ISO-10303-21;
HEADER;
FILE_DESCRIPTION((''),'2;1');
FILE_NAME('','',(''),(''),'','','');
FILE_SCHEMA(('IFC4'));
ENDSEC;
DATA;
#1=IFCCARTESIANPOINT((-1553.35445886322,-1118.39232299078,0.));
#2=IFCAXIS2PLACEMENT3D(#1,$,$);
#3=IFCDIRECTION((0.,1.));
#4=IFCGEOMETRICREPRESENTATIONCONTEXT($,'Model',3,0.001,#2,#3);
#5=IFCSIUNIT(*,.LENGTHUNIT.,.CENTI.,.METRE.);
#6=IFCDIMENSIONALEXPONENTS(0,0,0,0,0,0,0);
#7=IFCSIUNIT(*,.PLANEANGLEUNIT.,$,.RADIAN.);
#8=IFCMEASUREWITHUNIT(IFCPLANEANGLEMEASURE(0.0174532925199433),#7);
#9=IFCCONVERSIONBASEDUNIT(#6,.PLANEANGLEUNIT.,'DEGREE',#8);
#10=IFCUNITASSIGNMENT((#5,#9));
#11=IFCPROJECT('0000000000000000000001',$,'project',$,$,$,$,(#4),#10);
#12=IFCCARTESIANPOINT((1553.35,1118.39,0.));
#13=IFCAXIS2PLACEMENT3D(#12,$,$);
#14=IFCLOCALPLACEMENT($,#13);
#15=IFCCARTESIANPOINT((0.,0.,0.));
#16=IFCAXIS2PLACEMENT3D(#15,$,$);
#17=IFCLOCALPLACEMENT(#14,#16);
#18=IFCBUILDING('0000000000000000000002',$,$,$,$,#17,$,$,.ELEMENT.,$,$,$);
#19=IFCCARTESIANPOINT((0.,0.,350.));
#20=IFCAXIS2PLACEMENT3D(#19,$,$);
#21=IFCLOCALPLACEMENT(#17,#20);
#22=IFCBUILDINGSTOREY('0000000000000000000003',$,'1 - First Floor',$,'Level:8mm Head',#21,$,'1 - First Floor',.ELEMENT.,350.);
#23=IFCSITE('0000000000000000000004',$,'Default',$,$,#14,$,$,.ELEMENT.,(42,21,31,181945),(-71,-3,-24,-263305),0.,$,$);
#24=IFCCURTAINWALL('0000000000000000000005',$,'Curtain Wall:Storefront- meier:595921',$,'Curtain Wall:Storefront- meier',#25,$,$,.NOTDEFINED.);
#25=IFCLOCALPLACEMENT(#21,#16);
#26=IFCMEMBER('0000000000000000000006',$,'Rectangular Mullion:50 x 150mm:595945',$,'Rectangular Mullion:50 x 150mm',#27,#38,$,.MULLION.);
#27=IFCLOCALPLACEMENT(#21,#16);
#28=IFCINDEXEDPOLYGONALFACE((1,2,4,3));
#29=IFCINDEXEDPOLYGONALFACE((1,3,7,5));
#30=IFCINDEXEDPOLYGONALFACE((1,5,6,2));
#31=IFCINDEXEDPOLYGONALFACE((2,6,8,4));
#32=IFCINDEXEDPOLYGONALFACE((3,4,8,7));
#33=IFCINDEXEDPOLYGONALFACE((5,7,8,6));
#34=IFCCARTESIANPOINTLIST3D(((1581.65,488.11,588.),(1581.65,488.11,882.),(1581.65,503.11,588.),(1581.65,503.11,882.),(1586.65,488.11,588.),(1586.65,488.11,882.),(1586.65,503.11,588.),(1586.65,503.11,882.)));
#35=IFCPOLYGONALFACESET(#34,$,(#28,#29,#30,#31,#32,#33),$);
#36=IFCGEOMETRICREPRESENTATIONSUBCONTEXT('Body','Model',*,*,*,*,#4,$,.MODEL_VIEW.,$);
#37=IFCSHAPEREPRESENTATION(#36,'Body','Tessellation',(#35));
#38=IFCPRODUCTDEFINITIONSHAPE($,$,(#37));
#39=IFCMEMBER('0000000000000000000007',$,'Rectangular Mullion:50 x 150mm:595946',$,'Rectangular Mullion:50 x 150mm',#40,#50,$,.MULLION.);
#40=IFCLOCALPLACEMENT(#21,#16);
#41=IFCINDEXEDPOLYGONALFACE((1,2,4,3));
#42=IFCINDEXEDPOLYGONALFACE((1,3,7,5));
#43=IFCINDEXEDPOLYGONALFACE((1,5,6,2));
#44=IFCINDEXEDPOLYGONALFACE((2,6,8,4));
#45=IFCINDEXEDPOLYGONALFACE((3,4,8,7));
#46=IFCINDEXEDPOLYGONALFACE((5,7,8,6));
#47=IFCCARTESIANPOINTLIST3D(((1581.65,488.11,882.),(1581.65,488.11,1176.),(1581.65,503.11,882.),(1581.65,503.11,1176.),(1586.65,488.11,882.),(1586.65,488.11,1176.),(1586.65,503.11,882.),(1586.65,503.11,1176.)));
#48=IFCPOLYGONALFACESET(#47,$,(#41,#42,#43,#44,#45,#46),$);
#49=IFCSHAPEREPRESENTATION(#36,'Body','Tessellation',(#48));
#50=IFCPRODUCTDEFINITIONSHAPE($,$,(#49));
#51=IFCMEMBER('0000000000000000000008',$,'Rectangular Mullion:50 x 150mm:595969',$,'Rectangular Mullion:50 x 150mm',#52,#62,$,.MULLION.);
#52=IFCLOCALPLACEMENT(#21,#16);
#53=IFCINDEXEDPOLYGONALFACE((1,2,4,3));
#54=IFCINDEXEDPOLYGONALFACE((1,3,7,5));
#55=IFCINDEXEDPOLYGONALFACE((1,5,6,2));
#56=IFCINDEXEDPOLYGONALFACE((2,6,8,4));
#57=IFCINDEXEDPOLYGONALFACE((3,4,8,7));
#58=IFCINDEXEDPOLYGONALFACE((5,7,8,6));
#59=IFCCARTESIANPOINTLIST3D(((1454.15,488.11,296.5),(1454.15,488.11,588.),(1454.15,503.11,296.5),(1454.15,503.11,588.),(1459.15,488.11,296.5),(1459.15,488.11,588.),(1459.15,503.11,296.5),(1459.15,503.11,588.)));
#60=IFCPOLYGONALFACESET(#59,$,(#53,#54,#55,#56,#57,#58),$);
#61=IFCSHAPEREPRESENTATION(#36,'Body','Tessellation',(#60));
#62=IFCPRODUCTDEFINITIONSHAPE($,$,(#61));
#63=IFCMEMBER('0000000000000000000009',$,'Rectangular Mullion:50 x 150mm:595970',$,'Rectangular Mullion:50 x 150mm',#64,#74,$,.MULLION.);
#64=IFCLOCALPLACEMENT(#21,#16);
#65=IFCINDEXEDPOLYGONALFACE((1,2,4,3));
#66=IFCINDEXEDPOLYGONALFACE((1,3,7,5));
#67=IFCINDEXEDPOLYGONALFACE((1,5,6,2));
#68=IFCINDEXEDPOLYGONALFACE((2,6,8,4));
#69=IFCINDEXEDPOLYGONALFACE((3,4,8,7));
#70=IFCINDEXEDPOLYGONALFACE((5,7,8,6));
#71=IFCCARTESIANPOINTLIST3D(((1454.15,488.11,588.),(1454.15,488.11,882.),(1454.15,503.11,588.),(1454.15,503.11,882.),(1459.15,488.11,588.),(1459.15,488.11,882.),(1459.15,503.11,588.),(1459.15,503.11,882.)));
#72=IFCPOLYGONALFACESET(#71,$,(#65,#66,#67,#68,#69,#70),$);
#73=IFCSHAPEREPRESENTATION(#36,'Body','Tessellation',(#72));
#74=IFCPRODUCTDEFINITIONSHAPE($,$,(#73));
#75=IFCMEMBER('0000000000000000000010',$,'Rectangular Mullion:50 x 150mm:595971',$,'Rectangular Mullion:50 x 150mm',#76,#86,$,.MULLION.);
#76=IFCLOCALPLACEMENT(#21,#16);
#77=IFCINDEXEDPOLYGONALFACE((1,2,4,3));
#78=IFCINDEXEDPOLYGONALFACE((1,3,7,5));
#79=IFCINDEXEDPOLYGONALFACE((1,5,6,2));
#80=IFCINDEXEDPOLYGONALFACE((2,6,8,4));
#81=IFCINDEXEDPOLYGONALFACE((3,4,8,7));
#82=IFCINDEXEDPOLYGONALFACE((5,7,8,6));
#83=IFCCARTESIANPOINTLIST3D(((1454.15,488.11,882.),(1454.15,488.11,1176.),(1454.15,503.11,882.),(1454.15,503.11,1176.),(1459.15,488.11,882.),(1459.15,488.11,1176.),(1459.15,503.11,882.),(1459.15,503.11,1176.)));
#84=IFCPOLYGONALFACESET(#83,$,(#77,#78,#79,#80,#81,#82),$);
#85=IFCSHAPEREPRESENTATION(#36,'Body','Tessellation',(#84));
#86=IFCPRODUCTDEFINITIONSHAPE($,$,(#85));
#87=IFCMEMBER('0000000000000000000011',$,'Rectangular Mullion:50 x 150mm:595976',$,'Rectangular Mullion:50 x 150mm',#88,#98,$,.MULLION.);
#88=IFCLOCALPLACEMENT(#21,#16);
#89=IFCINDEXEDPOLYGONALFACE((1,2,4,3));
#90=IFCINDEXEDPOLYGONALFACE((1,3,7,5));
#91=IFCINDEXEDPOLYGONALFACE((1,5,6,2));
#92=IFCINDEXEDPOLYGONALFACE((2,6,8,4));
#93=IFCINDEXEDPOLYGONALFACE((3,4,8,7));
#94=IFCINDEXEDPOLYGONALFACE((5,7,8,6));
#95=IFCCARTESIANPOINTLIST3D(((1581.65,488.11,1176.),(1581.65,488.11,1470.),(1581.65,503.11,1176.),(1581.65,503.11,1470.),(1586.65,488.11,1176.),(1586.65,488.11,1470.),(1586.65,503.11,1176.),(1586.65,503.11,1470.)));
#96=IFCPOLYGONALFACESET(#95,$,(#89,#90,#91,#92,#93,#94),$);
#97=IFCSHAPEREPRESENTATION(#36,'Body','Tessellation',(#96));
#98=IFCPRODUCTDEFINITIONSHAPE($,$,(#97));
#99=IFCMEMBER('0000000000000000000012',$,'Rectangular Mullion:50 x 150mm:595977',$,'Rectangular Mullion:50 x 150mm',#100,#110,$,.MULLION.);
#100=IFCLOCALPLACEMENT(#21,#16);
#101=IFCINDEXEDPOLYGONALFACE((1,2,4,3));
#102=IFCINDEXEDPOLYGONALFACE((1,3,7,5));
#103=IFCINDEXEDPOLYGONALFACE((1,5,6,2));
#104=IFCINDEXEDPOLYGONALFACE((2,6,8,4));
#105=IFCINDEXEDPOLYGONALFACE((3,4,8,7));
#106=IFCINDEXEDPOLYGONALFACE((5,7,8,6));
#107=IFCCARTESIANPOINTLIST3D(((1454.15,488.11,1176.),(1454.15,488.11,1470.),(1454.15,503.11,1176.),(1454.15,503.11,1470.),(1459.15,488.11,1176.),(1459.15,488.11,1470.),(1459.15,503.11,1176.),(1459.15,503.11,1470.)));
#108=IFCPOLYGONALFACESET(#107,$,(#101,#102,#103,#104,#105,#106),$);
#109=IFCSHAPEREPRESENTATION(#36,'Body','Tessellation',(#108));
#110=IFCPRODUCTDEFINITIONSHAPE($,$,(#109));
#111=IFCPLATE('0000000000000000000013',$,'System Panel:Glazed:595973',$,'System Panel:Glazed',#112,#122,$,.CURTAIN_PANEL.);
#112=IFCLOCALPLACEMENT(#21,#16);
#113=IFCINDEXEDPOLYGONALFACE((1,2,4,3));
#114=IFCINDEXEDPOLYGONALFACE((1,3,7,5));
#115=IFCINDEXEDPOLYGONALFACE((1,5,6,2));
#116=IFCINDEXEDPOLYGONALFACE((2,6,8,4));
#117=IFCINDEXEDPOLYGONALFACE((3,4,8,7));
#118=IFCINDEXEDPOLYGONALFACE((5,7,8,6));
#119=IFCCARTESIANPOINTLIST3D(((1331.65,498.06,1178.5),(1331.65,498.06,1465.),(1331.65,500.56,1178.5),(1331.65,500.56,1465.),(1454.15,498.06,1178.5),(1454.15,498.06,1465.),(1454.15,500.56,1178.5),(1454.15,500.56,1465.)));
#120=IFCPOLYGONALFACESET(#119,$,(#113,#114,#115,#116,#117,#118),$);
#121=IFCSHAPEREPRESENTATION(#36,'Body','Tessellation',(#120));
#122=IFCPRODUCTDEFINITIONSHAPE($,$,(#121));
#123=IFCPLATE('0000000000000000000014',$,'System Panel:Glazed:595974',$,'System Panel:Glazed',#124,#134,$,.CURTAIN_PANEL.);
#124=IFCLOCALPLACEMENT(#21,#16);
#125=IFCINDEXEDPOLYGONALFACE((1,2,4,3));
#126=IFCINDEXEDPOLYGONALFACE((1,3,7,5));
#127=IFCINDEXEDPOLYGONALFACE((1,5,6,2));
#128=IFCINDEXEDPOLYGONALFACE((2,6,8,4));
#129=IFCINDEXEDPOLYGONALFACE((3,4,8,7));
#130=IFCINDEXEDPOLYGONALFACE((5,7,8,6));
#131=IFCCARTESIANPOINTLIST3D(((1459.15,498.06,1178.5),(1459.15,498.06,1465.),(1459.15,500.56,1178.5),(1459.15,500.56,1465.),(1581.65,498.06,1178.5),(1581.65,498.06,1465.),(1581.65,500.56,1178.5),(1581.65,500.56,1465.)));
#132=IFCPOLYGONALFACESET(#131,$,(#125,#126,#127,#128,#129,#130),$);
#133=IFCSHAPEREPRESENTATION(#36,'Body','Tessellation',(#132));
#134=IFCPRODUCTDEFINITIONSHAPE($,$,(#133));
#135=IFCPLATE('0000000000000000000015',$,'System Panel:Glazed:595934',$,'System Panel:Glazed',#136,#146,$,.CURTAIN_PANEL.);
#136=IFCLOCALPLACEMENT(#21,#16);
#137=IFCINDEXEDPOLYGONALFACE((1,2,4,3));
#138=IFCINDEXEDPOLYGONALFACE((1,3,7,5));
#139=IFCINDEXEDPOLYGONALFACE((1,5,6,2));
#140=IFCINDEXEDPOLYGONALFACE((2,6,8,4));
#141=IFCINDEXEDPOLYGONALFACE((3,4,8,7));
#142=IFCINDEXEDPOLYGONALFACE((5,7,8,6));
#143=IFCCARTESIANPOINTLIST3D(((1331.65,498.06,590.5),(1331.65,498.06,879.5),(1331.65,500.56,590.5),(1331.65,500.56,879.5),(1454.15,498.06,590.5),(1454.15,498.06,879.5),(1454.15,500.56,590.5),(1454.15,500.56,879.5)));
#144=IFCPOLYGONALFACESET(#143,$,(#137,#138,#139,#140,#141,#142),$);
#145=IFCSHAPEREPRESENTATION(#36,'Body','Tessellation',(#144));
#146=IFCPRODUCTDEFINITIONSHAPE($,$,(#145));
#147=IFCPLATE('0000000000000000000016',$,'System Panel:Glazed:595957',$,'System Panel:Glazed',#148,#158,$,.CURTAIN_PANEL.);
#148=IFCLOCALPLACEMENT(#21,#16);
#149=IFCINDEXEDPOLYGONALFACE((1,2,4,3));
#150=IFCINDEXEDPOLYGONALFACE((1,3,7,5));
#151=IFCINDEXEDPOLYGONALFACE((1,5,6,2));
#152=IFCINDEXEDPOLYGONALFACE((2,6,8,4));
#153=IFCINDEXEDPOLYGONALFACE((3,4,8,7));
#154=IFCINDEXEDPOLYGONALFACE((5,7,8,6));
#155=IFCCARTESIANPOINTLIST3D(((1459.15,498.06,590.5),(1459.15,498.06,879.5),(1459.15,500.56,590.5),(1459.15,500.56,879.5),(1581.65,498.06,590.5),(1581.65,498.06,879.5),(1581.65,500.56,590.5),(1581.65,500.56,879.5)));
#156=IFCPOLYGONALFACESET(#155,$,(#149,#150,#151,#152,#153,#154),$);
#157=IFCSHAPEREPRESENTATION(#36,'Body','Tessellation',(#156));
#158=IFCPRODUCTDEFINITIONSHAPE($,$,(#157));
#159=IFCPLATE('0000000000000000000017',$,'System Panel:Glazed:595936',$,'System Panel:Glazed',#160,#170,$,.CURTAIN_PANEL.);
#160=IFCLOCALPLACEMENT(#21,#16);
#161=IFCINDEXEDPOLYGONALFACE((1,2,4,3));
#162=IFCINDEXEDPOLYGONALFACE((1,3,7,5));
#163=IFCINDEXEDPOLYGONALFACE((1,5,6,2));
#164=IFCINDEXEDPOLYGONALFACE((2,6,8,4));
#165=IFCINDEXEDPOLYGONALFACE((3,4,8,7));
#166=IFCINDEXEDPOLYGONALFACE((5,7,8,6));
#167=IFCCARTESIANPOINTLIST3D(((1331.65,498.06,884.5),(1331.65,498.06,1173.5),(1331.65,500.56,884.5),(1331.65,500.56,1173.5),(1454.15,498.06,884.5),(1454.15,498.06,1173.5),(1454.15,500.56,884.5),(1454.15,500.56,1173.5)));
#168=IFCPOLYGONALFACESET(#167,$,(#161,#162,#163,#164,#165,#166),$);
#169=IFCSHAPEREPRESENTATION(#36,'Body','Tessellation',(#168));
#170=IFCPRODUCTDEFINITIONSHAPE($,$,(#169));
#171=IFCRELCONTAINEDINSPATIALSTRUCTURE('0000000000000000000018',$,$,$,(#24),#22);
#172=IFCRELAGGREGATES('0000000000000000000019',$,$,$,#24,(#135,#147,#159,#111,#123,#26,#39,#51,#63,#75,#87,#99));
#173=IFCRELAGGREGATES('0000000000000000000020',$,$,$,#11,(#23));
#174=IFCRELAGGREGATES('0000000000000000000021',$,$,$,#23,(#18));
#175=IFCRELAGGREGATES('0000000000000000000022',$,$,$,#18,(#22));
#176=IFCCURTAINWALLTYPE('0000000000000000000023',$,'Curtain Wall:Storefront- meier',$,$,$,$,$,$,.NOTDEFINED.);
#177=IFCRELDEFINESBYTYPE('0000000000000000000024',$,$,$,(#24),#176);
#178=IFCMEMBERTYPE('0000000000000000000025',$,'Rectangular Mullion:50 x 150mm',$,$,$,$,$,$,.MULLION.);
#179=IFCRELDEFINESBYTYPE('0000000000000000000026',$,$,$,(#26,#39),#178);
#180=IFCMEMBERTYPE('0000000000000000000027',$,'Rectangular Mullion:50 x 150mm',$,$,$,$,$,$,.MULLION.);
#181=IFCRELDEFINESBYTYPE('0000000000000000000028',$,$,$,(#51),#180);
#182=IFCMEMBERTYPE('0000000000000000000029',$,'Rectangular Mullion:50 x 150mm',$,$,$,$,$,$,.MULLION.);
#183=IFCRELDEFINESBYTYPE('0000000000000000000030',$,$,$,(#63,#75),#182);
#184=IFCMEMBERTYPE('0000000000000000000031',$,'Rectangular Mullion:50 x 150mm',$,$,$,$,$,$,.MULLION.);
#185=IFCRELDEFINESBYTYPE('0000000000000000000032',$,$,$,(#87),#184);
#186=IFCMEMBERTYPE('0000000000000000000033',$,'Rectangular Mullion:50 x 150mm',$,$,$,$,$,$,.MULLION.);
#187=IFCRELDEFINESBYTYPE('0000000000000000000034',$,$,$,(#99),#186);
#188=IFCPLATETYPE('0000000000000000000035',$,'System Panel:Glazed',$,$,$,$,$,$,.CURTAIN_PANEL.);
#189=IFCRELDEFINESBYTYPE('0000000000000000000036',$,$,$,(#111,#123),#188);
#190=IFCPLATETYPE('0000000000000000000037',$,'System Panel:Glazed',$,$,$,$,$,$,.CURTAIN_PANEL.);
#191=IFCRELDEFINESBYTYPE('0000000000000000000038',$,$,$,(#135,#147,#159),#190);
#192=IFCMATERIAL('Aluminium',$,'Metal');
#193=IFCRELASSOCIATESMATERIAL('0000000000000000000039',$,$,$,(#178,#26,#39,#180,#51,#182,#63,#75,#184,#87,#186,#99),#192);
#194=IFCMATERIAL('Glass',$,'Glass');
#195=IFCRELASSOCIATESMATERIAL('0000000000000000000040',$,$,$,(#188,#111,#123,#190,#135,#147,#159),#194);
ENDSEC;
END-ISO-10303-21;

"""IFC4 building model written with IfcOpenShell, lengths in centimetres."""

from ifc_helpers import new_model, entity, si_unit, converted_unit, direction, frame, origin, place, context, subcontext, project, spatial, indexed_curve, outline, extrude, source, transform, mapped, material, type_object, type_shapes, element, aggregate, save


model = new_model("IFC4")

# Units and contexts
model_context = context("Model", 3, precision=0.001, world=frame((-1553.35445886322, -1118.39232299078, 0.0)), true_north=direction((0.0, 1.0)))
body_context = subcontext(model_context, "Body", "Model", "MODEL_VIEW")
ifc_project = project(units=[si_unit("LENGTHUNIT", "METRE", prefix="CENTI"), converted_unit("PLANEANGLEUNIT", "DEGREE", entity("IfcPlaneAngleMeasure", 0.0174532925199433), si_unit("PLANEANGLEUNIT", "RADIAN"), dimensions=[0, 0, 0, 0, 0, 0, 0])], contexts=[model_context])

# Site, building, storey
site_placement = place(None, frame((1553.35, 1118.39, 0.0)))
site = spatial("IfcSite", under=ifc_project, at=site_placement, Name="Default", CompositionType="ELEMENT", RefLatitude=(42, 21, 31, 181945), RefLongitude=(-71, -3, -24, -263305), RefElevation=0.0)
building_placement = place(site_placement, origin())
building = spatial("IfcBuilding", under=site, at=building_placement, CompositionType="ELEMENT")
storey_placement = place(building_placement, frame((0.0, 0.0, 350.0)))
storey = spatial("IfcBuildingStorey", under=building, at=storey_placement, Name="1 - First Floor", ObjectType="Level:8mm Head", LongName="1 - First Floor", CompositionType="ELEMENT", Elevation=350.0)

# Curtain wall, members, plates
curtain_wall_type = type_object("IfcCurtainWallType", Name="Curtain Wall:Storefront- meier", PredefinedType="NOTDEFINED")
curtain_wall_placement = place(storey_placement, frame((0.0, 0.0, -350.0)))
curtain_wall = element("IfcCurtainWall", 1, at=curtain_wall_placement, inside=storey, type_object=curtain_wall_type, Name="Curtain Wall:Storefront- meier:595921", ObjectType="Curtain Wall:Storefront- meier", PredefinedType="NOTDEFINED")
ifc_material_1 = material(Name="Aluminium", Category="Metal")
member_type_1 = type_object("IfcMemberType", Name="Rectangular Mullion:50 x 150mm", PredefinedType="MULLION", material=ifc_material_1)
shared_shape_1 = source(origin(), body_context, "Body", "SweptSolid", [
    extrude(outline(indexed_curve([(-2.5, -7.5), (2.5, -7.5), (2.5, 7.5), (-2.5, 7.5), (-2.5, -7.5)], self_intersect=False)), frame((-2.5, 0.0, -294.0), z_axis=(0.0, 0.0, 1.0), x_axis=(-1.0, 0.0, 0.0)), (0.0, 0.0, 1.0), 294.0),
])
type_shapes(member_type_1, [shared_shape_1])
member_1_placement = place(curtain_wall_placement, frame((1586.65, 495.61, 938.0), z_axis=(0.0, 0.0, -1.0), x_axis=(1.0, 0.0, 0.0)))
member_1 = element("IfcMember", 2, at=member_1_placement, type_object=member_type_1, material=ifc_material_1, Name="Rectangular Mullion:50 x 150mm:595945", ObjectType="Rectangular Mullion:50 x 150mm", PredefinedType="MULLION", context=body_context, shape_type="MappedRepresentation", body=[
    mapped(shared_shape_1, transform((0.0, 0.0, 0.0), scale=1.0)),
])
member_2_placement = place(curtain_wall_placement, frame((1586.65, 495.61, 1232.0), z_axis=(0.0, 0.0, -1.0), x_axis=(1.0, 0.0, 0.0)))
member_2 = element("IfcMember", 3, at=member_2_placement, type_object=member_type_1, material=ifc_material_1, Name="Rectangular Mullion:50 x 150mm:595946", ObjectType="Rectangular Mullion:50 x 150mm", PredefinedType="MULLION", context=body_context, shape_type="MappedRepresentation", body=[
    mapped(shared_shape_1, transform((0.0, 0.0, 0.0), scale=1.0)),
])
member_type_2 = type_object("IfcMemberType", Name="Rectangular Mullion:50 x 150mm", PredefinedType="MULLION", material=ifc_material_1)
shared_shape_2 = source(origin(), body_context, "Body", "SweptSolid", [
    extrude(outline(indexed_curve([(-2.5, -7.5), (2.5, -7.5), (2.5, 7.5), (-2.5, 7.5), (-2.5, -7.5)], self_intersect=False)), frame((0.0, 0.0, -291.5), z_axis=(0.0, 0.0, 1.0), x_axis=(-1.0, 0.0, 0.0)), (0.0, 0.0, 1.0), 291.5),
])
type_shapes(member_type_2, [shared_shape_2])
member_3_placement = place(curtain_wall_placement, frame((1456.65, 495.61, 646.5), z_axis=(0.0, 0.0, -1.0), x_axis=(1.0, 0.0, 0.0)))
member_3 = element("IfcMember", 4, at=member_3_placement, type_object=member_type_2, material=ifc_material_1, Name="Rectangular Mullion:50 x 150mm:595969", ObjectType="Rectangular Mullion:50 x 150mm", PredefinedType="MULLION", context=body_context, shape_type="MappedRepresentation", body=[
    mapped(shared_shape_2, transform((0.0, 0.0, 0.0), scale=1.0)),
])
member_type_3 = type_object("IfcMemberType", Name="Rectangular Mullion:50 x 150mm", PredefinedType="MULLION", material=ifc_material_1)
shared_shape_3 = source(origin(), body_context, "Body", "SweptSolid", [
    extrude(outline(indexed_curve([(-2.5, -7.5), (2.5, -7.5), (2.5, 7.5), (-2.5, 7.5), (-2.5, -7.5)], self_intersect=False)), frame((0.0, 0.0, -294.0), z_axis=(0.0, 0.0, 1.0), x_axis=(-1.0, 0.0, 0.0)), (0.0, 0.0, 1.0), 294.0),
])
type_shapes(member_type_3, [shared_shape_3])
member_4_placement = place(curtain_wall_placement, frame((1456.65, 495.61, 938.0), z_axis=(0.0, 0.0, -1.0), x_axis=(1.0, 0.0, 0.0)))
member_4 = element("IfcMember", 5, at=member_4_placement, type_object=member_type_3, material=ifc_material_1, Name="Rectangular Mullion:50 x 150mm:595970", ObjectType="Rectangular Mullion:50 x 150mm", PredefinedType="MULLION", context=body_context, shape_type="MappedRepresentation", body=[
    mapped(shared_shape_3, transform((0.0, 0.0, 0.0), scale=1.0)),
])
member_5_placement = place(curtain_wall_placement, frame((1456.65, 495.61, 1232.0), z_axis=(0.0, 0.0, -1.0), x_axis=(1.0, 0.0, 0.0)))
member_5 = element("IfcMember", 6, at=member_5_placement, type_object=member_type_3, material=ifc_material_1, Name="Rectangular Mullion:50 x 150mm:595971", ObjectType="Rectangular Mullion:50 x 150mm", PredefinedType="MULLION", context=body_context, shape_type="MappedRepresentation", body=[
    mapped(shared_shape_3, transform((0.0, 0.0, 0.0), scale=1.0)),
])
member_type_4 = type_object("IfcMemberType", Name="Rectangular Mullion:50 x 150mm", PredefinedType="MULLION", material=ifc_material_1)
shared_shape_4 = source(origin(), body_context, "Body", "SweptSolid", [
    extrude(outline(indexed_curve([(-2.5, -7.5), (2.5, -7.5), (2.5, 7.5), (-2.5, 7.5), (-2.5, -7.5)], self_intersect=False)), frame((-2.5, 0.0, -294.0), z_axis=(0.0, 0.0, 1.0), x_axis=(-1.0, 0.0, 0.0)), (0.0, 0.0, 1.0), 294.0),
])
type_shapes(member_type_4, [shared_shape_4])
member_6_placement = place(curtain_wall_placement, frame((1586.65, 495.61, 1526.0), z_axis=(0.0, 0.0, -1.0), x_axis=(1.0, 0.0, 0.0)))
member_6 = element("IfcMember", 7, at=member_6_placement, type_object=member_type_4, material=ifc_material_1, Name="Rectangular Mullion:50 x 150mm:595976", ObjectType="Rectangular Mullion:50 x 150mm", PredefinedType="MULLION", context=body_context, shape_type="MappedRepresentation", body=[
    mapped(shared_shape_4, transform((0.0, 0.0, 0.0), scale=1.0)),
])
member_type_5 = type_object("IfcMemberType", Name="Rectangular Mullion:50 x 150mm", PredefinedType="MULLION", material=ifc_material_1)
shared_shape_5 = source(origin(), body_context, "Body", "SweptSolid", [
    extrude(outline(indexed_curve([(-2.5, -7.5), (2.5, -7.5), (2.5, 7.5), (-2.5, 7.5), (-2.5, -7.5)], self_intersect=False)), frame((0.0, 0.0, -294.0), z_axis=(0.0, 0.0, 1.0), x_axis=(-1.0, 0.0, 0.0)), (0.0, 0.0, 1.0), 294.0),
])
type_shapes(member_type_5, [shared_shape_5])
member_7_placement = place(curtain_wall_placement, frame((1456.65, 495.61, 1526.0), z_axis=(0.0, 0.0, -1.0), x_axis=(1.0, 0.0, 0.0)))
member_7 = element("IfcMember", 8, at=member_7_placement, type_object=member_type_5, material=ifc_material_1, Name="Rectangular Mullion:50 x 150mm:595977", ObjectType="Rectangular Mullion:50 x 150mm", PredefinedType="MULLION", context=body_context, shape_type="MappedRepresentation", body=[
    mapped(shared_shape_5, transform((0.0, 0.0, 0.0), scale=1.0)),
])
ifc_material_2 = material(Name="Glass", Category="Glass")
plate_type_1 = type_object("IfcPlateType", Name="System Panel:Glazed", PredefinedType="CURTAIN_PANEL", material=ifc_material_2)
shared_shape_6 = source(origin(), body_context, "Body", "SweptSolid", [
    extrude(outline(indexed_curve([(-1.25, -61.25), (1.25, -61.25), (1.25, 61.25), (-1.25, 61.25), (-1.25, -61.25)], self_intersect=False)), frame((0.0, 3.7, 0.0), z_axis=(0.0, 0.0, 1.0), x_axis=(0.0, 1.0, 0.0)), (0.0, 0.0, 1.0), 286.5),
])
type_shapes(plate_type_1, [shared_shape_6])
plate_1_placement = place(curtain_wall_placement, frame((1392.9, 495.61, 1528.5)))
plate_1 = element("IfcPlate", 9, at=plate_1_placement, type_object=plate_type_1, material=ifc_material_2, Name="System Panel:Glazed:595973", ObjectType="System Panel:Glazed", PredefinedType="CURTAIN_PANEL", context=body_context, shape_type="MappedRepresentation", body=[
    mapped(shared_shape_6, transform((0.0, 0.0, 0.0), scale=1.0)),
])
plate_2_placement = place(curtain_wall_placement, frame((1520.4, 495.61, 1528.5)))
plate_2 = element("IfcPlate", 10, at=plate_2_placement, type_object=plate_type_1, material=ifc_material_2, Name="System Panel:Glazed:595974", ObjectType="System Panel:Glazed", PredefinedType="CURTAIN_PANEL", context=body_context, shape_type="MappedRepresentation", body=[
    mapped(shared_shape_6, transform((0.0, 0.0, 0.0), scale=1.0)),
])
plate_type_2 = type_object("IfcPlateType", Name="System Panel:Glazed", PredefinedType="CURTAIN_PANEL", material=ifc_material_2)
shared_shape_7 = source(origin(), body_context, "Body", "SweptSolid", [
    extrude(outline(indexed_curve([(-1.25, -61.25), (1.25, -61.25), (1.25, 61.25), (-1.25, 61.25), (-1.25, -61.25)], self_intersect=False)), frame((0.0, 3.7, 0.0), z_axis=(0.0, 0.0, 1.0), x_axis=(0.0, 1.0, 0.0)), (0.0, 0.0, 1.0), 289.0),
])
type_shapes(plate_type_2, [shared_shape_7])
plate_3_placement = place(curtain_wall_placement, frame((1392.9, 495.61, 940.5)))
plate_3 = element("IfcPlate", 11, at=plate_3_placement, type_object=plate_type_2, material=ifc_material_2, Name="System Panel:Glazed:595934", ObjectType="System Panel:Glazed", PredefinedType="CURTAIN_PANEL", context=body_context, shape_type="MappedRepresentation", body=[
    mapped(shared_shape_7, transform((0.0, 0.0, 0.0), scale=1.0)),
])
plate_4_placement = place(curtain_wall_placement, frame((1520.4, 495.61, 940.5)))
plate_4 = element("IfcPlate", 12, at=plate_4_placement, type_object=plate_type_2, material=ifc_material_2, Name="System Panel:Glazed:595957", ObjectType="System Panel:Glazed", PredefinedType="CURTAIN_PANEL", context=body_context, shape_type="MappedRepresentation", body=[
    mapped(shared_shape_7, transform((0.0, 0.0, 0.0), scale=1.0)),
])
plate_5_placement = place(curtain_wall_placement, frame((1392.9, 495.61, 1234.5)))
plate_5 = element("IfcPlate", 13, at=plate_5_placement, type_object=plate_type_2, material=ifc_material_2, Name="System Panel:Glazed:595936", ObjectType="System Panel:Glazed", PredefinedType="CURTAIN_PANEL", context=body_context, shape_type="MappedRepresentation", body=[
    mapped(shared_shape_7, transform((0.0, 0.0, 0.0), scale=1.0)),
])
aggregate(curtain_wall, [plate_3, plate_4, plate_5, plate_1, plate_2, member_1, member_2, member_3, member_4, member_5, member_6, member_7])

save(model, "model.ifc")
